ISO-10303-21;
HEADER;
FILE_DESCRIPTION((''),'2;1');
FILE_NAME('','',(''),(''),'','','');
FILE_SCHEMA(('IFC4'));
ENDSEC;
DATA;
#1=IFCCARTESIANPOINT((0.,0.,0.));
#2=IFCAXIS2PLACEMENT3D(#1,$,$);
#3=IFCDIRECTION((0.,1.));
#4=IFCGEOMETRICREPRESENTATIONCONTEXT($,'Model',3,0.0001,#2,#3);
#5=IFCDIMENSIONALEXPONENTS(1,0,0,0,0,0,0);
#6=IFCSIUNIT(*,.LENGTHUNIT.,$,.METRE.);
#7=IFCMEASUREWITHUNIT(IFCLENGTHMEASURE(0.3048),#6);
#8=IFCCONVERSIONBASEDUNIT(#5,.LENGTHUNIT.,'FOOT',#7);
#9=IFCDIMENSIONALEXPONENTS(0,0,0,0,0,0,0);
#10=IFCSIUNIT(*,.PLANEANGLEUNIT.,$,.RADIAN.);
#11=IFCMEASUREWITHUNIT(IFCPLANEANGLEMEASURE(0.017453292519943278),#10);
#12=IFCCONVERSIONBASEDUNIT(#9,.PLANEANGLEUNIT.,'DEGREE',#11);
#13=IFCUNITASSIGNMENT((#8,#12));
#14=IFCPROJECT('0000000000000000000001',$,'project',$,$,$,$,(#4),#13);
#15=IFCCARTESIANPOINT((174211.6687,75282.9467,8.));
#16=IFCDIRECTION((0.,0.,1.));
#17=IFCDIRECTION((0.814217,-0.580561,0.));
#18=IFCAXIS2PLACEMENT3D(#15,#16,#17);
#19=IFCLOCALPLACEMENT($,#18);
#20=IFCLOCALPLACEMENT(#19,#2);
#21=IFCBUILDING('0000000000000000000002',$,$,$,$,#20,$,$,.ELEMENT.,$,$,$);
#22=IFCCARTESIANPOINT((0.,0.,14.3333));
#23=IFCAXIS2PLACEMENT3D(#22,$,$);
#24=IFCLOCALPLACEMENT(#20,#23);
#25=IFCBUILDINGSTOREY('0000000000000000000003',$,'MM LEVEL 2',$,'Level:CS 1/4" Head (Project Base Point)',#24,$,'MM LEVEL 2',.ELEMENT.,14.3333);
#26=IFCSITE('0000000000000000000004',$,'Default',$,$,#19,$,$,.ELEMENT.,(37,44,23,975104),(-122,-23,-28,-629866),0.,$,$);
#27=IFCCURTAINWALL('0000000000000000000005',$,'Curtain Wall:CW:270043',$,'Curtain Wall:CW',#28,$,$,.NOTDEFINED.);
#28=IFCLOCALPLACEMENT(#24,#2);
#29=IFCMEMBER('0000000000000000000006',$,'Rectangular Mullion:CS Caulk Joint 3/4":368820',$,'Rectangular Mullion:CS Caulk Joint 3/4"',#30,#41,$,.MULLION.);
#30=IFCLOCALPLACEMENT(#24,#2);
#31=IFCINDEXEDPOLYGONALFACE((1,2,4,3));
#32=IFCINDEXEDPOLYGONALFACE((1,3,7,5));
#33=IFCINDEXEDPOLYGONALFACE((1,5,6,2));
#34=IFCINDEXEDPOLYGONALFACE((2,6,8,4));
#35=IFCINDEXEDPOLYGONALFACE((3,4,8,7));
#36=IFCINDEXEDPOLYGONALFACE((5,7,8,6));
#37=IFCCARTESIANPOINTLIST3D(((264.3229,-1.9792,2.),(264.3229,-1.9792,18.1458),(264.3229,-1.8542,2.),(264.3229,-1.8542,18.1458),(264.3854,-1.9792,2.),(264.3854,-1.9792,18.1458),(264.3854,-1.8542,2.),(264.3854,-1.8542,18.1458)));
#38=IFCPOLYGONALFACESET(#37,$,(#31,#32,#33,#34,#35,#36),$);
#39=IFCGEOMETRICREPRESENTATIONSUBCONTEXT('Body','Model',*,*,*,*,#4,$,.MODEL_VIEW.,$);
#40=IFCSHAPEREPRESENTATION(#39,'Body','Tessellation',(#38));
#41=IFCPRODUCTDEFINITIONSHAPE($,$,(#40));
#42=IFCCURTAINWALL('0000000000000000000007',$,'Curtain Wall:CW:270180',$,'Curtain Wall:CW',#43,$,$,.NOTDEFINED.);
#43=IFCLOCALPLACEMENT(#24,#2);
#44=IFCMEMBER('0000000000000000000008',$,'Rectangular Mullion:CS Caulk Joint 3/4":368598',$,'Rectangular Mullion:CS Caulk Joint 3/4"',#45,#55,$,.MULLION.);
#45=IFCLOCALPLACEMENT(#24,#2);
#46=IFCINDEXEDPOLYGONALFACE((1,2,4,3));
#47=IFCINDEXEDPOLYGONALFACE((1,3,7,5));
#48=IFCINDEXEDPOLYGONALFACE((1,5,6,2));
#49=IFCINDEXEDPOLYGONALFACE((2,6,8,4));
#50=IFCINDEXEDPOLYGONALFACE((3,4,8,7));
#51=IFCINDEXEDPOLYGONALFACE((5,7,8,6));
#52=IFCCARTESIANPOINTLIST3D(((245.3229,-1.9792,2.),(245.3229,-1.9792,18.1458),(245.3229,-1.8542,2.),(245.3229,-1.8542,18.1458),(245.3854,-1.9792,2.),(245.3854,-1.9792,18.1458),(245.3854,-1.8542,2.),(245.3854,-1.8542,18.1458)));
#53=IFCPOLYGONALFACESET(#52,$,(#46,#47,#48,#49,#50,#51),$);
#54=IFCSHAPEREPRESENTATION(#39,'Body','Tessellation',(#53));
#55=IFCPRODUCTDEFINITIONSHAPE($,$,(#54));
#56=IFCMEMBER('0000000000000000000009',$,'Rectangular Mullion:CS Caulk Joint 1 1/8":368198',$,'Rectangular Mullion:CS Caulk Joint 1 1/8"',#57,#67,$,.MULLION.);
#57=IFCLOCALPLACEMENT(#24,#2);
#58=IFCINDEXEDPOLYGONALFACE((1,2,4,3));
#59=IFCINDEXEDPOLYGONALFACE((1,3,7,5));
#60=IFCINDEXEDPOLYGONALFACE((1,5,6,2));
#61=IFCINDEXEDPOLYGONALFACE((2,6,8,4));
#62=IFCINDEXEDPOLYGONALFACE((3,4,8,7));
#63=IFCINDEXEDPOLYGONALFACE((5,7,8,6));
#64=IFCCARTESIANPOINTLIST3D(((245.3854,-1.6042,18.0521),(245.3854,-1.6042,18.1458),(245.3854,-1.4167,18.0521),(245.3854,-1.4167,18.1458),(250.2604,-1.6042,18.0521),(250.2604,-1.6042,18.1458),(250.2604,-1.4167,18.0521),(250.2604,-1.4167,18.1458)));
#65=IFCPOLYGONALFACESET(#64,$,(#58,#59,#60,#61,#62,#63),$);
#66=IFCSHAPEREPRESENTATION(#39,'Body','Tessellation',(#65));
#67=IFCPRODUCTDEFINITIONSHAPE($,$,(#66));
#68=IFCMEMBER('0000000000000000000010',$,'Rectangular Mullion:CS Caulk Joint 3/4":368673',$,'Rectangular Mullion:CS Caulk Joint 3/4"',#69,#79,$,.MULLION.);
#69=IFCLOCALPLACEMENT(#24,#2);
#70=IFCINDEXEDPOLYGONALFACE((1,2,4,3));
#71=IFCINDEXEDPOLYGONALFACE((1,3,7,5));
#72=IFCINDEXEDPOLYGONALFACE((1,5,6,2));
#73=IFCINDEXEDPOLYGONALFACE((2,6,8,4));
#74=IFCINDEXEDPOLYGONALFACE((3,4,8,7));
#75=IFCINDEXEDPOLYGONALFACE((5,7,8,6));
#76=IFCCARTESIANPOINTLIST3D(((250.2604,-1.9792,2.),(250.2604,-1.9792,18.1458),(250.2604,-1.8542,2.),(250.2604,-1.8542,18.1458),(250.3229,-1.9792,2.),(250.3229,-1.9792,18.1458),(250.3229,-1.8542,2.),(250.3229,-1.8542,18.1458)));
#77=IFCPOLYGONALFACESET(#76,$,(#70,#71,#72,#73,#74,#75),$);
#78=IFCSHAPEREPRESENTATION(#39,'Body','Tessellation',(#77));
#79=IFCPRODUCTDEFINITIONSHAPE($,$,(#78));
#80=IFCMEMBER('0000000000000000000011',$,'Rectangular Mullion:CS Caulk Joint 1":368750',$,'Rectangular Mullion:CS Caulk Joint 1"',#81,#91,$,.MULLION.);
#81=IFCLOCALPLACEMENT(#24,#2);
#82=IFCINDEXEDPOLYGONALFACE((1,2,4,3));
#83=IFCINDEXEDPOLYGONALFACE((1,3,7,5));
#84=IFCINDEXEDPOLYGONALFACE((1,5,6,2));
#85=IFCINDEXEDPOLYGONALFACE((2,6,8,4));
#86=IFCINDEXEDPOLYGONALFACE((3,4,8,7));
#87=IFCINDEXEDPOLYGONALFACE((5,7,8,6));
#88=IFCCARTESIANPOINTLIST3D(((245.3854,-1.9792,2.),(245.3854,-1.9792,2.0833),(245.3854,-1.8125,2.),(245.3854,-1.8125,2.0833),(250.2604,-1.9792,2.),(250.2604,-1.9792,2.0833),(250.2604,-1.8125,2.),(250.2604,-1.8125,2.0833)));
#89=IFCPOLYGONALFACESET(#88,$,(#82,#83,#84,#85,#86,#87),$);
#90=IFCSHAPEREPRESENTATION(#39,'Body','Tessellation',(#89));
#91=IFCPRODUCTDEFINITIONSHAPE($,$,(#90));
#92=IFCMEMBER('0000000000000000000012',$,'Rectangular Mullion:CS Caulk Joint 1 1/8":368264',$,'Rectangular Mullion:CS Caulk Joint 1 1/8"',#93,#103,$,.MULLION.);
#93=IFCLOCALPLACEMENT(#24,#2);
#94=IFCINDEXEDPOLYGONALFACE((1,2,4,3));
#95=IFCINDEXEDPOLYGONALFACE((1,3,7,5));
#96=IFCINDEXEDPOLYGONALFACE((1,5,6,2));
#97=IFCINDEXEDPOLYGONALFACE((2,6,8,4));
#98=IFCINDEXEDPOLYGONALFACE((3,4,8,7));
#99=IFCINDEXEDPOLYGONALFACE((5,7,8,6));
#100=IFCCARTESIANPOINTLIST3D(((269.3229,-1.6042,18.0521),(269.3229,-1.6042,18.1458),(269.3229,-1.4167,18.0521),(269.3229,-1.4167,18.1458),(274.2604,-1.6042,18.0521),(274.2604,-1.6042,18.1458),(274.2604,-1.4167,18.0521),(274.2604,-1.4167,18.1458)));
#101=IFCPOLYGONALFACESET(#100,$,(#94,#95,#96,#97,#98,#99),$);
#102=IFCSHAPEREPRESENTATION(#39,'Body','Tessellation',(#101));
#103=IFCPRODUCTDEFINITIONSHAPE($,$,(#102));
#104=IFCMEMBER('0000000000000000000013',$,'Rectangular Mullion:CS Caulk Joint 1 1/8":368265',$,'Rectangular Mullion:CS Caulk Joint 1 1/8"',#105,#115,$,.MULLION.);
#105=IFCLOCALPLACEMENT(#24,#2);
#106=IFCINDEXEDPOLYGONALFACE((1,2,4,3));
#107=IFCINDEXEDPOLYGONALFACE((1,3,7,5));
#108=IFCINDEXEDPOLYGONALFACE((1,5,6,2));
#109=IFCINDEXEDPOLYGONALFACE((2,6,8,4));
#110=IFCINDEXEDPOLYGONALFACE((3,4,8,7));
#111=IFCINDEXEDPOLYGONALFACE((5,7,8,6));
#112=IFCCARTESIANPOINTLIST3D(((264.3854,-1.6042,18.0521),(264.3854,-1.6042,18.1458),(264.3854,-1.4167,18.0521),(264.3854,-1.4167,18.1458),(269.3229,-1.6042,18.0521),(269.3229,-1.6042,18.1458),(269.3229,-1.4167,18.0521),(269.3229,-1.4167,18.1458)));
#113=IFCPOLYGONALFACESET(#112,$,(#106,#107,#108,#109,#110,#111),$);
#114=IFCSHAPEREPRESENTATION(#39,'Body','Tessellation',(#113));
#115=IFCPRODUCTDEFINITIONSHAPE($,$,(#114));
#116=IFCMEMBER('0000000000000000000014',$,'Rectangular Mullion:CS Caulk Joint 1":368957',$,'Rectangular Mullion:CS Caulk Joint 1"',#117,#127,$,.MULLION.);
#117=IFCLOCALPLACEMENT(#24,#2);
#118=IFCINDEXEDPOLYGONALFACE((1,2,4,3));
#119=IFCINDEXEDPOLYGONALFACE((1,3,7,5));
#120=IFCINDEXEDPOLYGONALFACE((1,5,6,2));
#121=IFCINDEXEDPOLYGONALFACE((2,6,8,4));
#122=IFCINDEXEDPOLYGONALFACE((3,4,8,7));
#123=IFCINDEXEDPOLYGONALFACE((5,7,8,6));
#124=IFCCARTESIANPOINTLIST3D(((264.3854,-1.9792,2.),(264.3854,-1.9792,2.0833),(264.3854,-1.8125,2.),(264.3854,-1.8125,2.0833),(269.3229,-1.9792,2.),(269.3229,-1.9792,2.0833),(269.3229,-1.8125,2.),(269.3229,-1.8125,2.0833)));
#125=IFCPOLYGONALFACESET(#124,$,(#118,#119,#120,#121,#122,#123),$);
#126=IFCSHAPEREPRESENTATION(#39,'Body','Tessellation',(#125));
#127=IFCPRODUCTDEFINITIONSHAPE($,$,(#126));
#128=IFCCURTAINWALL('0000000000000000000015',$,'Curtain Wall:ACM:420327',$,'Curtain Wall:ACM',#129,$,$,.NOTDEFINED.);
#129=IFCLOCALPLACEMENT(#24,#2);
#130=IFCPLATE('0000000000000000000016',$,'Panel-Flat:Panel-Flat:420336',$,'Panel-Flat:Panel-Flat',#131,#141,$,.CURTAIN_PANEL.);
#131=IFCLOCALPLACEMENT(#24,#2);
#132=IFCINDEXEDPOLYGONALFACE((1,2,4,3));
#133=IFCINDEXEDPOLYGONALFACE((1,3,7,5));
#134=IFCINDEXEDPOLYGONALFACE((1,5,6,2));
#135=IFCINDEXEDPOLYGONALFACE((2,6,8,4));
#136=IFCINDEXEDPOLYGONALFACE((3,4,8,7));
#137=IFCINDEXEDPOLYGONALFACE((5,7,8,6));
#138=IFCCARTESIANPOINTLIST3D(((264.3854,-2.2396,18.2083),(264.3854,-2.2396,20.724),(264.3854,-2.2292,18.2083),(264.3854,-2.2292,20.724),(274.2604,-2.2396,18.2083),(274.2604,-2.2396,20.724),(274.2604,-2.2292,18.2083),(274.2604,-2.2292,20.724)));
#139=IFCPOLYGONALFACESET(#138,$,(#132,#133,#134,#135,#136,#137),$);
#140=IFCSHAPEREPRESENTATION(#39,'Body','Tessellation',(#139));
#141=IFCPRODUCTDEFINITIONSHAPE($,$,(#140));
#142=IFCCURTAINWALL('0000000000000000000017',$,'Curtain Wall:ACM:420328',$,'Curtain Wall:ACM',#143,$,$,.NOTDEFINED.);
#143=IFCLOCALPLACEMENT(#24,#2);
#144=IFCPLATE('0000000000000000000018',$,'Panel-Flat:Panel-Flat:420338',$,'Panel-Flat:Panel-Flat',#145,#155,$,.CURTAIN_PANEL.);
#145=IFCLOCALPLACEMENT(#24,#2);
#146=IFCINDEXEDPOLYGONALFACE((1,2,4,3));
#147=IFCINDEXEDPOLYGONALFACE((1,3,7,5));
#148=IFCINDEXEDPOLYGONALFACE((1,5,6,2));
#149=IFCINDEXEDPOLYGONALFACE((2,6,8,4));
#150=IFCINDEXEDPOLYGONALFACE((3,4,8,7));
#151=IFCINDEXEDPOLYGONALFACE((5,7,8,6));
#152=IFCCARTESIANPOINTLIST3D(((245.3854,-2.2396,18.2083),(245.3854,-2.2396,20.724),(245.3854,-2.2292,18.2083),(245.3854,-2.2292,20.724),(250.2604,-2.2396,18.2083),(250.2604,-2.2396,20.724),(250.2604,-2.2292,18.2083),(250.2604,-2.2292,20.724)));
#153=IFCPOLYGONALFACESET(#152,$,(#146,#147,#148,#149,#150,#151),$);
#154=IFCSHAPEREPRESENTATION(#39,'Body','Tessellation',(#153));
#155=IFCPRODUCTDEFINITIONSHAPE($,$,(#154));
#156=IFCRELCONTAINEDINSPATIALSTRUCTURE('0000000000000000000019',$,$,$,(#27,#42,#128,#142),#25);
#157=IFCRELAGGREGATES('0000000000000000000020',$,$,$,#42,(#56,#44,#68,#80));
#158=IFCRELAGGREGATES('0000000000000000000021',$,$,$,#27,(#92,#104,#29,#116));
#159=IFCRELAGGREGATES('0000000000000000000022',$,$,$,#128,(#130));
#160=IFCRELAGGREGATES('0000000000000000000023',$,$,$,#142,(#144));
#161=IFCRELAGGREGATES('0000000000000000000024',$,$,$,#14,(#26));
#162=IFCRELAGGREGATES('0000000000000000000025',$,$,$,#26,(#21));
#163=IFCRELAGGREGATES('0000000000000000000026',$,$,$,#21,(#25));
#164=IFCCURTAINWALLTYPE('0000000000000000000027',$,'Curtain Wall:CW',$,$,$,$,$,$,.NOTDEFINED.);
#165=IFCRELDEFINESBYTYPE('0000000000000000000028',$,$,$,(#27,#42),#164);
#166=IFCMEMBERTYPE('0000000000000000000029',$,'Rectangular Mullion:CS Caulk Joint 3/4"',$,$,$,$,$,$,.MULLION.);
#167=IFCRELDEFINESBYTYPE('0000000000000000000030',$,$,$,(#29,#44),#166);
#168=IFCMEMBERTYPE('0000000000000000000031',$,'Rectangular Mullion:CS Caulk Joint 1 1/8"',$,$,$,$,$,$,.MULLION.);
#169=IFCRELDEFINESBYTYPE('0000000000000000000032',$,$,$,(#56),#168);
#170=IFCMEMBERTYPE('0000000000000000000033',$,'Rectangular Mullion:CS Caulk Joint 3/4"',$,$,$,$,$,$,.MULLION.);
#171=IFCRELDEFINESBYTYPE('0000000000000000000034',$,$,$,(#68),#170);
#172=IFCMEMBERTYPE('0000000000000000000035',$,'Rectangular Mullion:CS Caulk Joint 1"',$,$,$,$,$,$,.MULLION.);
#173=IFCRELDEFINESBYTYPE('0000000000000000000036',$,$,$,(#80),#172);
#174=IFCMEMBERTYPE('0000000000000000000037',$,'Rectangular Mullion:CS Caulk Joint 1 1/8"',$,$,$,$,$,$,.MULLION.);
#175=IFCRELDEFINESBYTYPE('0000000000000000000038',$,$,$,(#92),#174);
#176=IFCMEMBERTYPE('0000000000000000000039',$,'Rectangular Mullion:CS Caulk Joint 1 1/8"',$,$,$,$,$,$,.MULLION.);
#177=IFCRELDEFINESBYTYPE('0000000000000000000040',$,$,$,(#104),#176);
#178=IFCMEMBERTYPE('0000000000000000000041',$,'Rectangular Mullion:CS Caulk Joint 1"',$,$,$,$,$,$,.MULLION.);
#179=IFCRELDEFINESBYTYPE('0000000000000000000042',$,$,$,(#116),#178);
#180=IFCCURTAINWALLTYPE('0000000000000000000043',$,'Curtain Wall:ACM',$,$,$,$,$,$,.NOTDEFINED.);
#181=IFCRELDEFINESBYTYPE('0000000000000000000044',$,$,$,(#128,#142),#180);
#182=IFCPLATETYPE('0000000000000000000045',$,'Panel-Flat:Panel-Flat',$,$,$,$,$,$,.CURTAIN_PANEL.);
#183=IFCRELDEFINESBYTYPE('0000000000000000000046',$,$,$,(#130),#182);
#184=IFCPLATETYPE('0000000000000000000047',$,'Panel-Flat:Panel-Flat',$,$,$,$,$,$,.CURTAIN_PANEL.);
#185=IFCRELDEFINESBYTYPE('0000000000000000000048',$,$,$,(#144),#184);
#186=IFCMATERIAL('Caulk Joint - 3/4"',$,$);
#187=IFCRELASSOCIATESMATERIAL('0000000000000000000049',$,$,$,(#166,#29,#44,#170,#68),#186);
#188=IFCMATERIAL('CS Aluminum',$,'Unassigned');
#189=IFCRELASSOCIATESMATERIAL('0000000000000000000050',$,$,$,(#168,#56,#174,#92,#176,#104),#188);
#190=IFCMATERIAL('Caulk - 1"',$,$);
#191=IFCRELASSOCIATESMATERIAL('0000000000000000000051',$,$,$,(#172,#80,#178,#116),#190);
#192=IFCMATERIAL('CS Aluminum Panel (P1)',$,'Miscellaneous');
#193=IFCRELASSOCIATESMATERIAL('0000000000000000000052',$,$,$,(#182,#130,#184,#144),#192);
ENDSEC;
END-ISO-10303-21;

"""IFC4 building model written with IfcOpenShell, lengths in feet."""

from ifc_helpers import new_model, entity, si_unit, converted_unit, direction, frame, origin, place, context, subcontext, project, spatial, indexed_curve, outline, extrude, source, transform, mapped, material, type_object, type_shapes, element, aggregate, save


model = new_model("IFC4")

# Units and contexts
model_context = context("Model", 3, precision=0.0001, world=origin(), true_north=direction((0.0, 1.0)))
body_context = subcontext(model_context, "Body", "Model", "MODEL_VIEW")
ifc_project = project(units=[converted_unit("LENGTHUNIT", "FOOT", entity("IfcLengthMeasure", 0.3048), si_unit("LENGTHUNIT", "METRE"), dimensions=[1, 0, 0, 0, 0, 0, 0]), converted_unit("PLANEANGLEUNIT", "DEGREE", entity("IfcPlaneAngleMeasure", 0.017453292519943278), si_unit("PLANEANGLEUNIT", "RADIAN"), dimensions=[0, 0, 0, 0, 0, 0, 0])], contexts=[model_context])

# Site, building, storey
site_placement = place(None, frame((174211.6687, 75282.9467, 8.0), z_axis=(0.0, 0.0, 1.0), x_axis=(0.814217, -0.580561, 0.0)))
site = spatial("IfcSite", under=ifc_project, at=site_placement, Name="Default", CompositionType="ELEMENT", RefLatitude=(37, 44, 23, 975104), RefLongitude=(-122, -23, -28, -629866), RefElevation=0.0)
building_placement = place(site_placement, origin())
building = spatial("IfcBuilding", under=site, at=building_placement, CompositionType="ELEMENT")
storey_placement = place(building_placement, frame((0.0, 0.0, 14.3333)))
storey = spatial("IfcBuildingStorey", under=building, at=storey_placement, Name="MM LEVEL 2", ObjectType="Level:CS 1/4\" Head (Project Base Point)", LongName="MM LEVEL 2", CompositionType="ELEMENT", Elevation=14.3333)

# Curtain wall, member
curtain_wall_type_1 = type_object("IfcCurtainWallType", Name="Curtain Wall:CW", PredefinedType="NOTDEFINED")
curtain_wall_1_placement = place(storey_placement, frame((0.0, 0.0, -14.3333)))
curtain_wall_1 = element("IfcCurtainWall", 1, at=curtain_wall_1_placement, inside=storey, type_object=curtain_wall_type_1, Name="Curtain Wall:CW:270043", ObjectType="Curtain Wall:CW", PredefinedType="NOTDEFINED")
ifc_material_1 = material(Name="Caulk Joint - 3/4\"")
member_type_1 = type_object("IfcMemberType", Name="Rectangular Mullion:CS Caulk Joint 3/4\"", PredefinedType="MULLION", material=ifc_material_1)
shared_shape_1 = source(origin(), body_context, "Body", "SweptSolid", [
    extrude(outline(indexed_curve([(-0.0625, -0.0312), (0.0625, -0.0312), (0.0625, 0.0312), (-0.0625, 0.0312), (-0.0625, -0.0312)], self_intersect=False)), frame((-0.0312, 0.0625, -16.1458), z_axis=(0.0, 0.0, 1.0), x_axis=(0.0, -1.0, 0.0)), (0.0, 0.0, 1.0), 16.1458),
])
type_shapes(member_type_1, [shared_shape_1])
member_1_placement = place(curtain_wall_1_placement, frame((264.3229, -1.9792, 16.3333), z_axis=(0.0, 0.0, -1.0), x_axis=(-1.0, 0.0, 0.0)))
member_1 = element("IfcMember", 2, at=member_1_placement, type_object=member_type_1, material=ifc_material_1, Name="Rectangular Mullion:CS Caulk Joint 3/4\":368820", ObjectType="Rectangular Mullion:CS Caulk Joint 3/4\"", PredefinedType="MULLION", context=body_context, shape_type="MappedRepresentation", body=[
    mapped(shared_shape_1, transform((0.0, 0.0, 0.0), scale=1.0)),
])

# Curtain wall, members
curtain_wall_2_placement = place(storey_placement, frame((0.0, 0.0, -14.3333)))
curtain_wall_2 = element("IfcCurtainWall", 3, at=curtain_wall_2_placement, inside=storey, type_object=curtain_wall_type_1, Name="Curtain Wall:CW:270180", ObjectType="Curtain Wall:CW", PredefinedType="NOTDEFINED")
member_2_placement = place(curtain_wall_2_placement, frame((245.3229, -1.9792, 16.3333), z_axis=(0.0, 0.0, -1.0), x_axis=(-1.0, 0.0, 0.0)))
member_2 = element("IfcMember", 4, at=member_2_placement, type_object=member_type_1, material=ifc_material_1, Name="Rectangular Mullion:CS Caulk Joint 3/4\":368598", ObjectType="Rectangular Mullion:CS Caulk Joint 3/4\"", PredefinedType="MULLION", context=body_context, shape_type="MappedRepresentation", body=[
    mapped(shared_shape_1, transform((0.0, 0.0, 0.0), scale=1.0)),
])
ifc_material_2 = material(Name="CS Aluminum", Category="Unassigned")
member_type_2 = type_object("IfcMemberType", Name="Rectangular Mullion:CS Caulk Joint 1 1/8\"", PredefinedType="MULLION", material=ifc_material_2)
shared_shape_2 = source(origin(), body_context, "Body", "SweptSolid", [
    extrude(outline(indexed_curve([(-0.0937, -0.0469), (0.0938, -0.0469), (0.0938, 0.0469), (-0.0937, 0.0469), (-0.0937, -0.0469)], self_intersect=False)), frame((-0.0469, 0.4688, -4.875), z_axis=(0.0, 0.0, 1.0), x_axis=(0.0, -1.0, 0.0)), (0.0, 0.0, 1.0), 4.875),
])
type_shapes(member_type_2, [shared_shape_2])
member_3_placement = place(curtain_wall_2_placement, frame((245.3854, -1.9792, 32.4792), z_axis=(-1.0, 0.0, 0.0), x_axis=(0.0, 0.0, 1.0)))
member_3 = element("IfcMember", 5, at=member_3_placement, type_object=member_type_2, material=ifc_material_2, Name="Rectangular Mullion:CS Caulk Joint 1 1/8\":368198", ObjectType="Rectangular Mullion:CS Caulk Joint 1 1/8\"", PredefinedType="MULLION", context=body_context, shape_type="MappedRepresentation", body=[
    mapped(shared_shape_2, transform((0.0, 0.0, 0.0), scale=1.0)),
])
member_type_3 = type_object("IfcMemberType", Name="Rectangular Mullion:CS Caulk Joint 3/4\"", PredefinedType="MULLION", material=ifc_material_1)
shared_shape_3 = source(origin(), body_context, "Body", "SweptSolid", [
    extrude(outline(indexed_curve([(-0.0312, -0.0625), (0.0312, -0.0625), (0.0312, 0.0625), (-0.0312, 0.0625), (-0.0312, -0.0625)], self_intersect=False)), frame((-0.0312, 0.0625, -16.1458), z_axis=(0.0, 0.0, 1.0), x_axis=(-1.0, 0.0, 0.0)), (0.0, 0.0, 1.0), 16.1458),
])
type_shapes(member_type_3, [shared_shape_3])
member_4_placement = place(curtain_wall_2_placement, frame((250.3229, -1.9792, 32.4792)))
member_4 = element("IfcMember", 6, at=member_4_placement, type_object=member_type_3, material=ifc_material_1, Name="Rectangular Mullion:CS Caulk Joint 3/4\":368673", ObjectType="Rectangular Mullion:CS Caulk Joint 3/4\"", PredefinedType="MULLION", context=body_context, shape_type="MappedRepresentation", body=[
    mapped(shared_shape_3, transform((0.0, 0.0, 0.0), scale=1.0)),
])
ifc_material_3 = material(Name="Caulk - 1\"")
member_type_4 = type_object("IfcMemberType", Name="Rectangular Mullion:CS Caulk Joint 1\"", PredefinedType="MULLION", material=ifc_material_3)
shared_shape_4 = source(origin(), body_context, "Body", "SweptSolid", [
    extrude(outline(indexed_curve([(-0.0417, -0.0833), (0.0417, -0.0833), (0.0417, 0.0833), (-0.0417, 0.0833), (-0.0417, -0.0833)], self_intersect=False)), frame((-0.0417, 0.0833, -4.875), z_axis=(0.0, 0.0, 1.0), x_axis=(-1.0, 0.0, 0.0)), (0.0, 0.0, 1.0), 4.875),
])
type_shapes(member_type_4, [shared_shape_4])
member_5_placement = place(curtain_wall_2_placement, frame((250.2604, -1.9792, 16.3333), z_axis=(1.0, 0.0, 0.0), x_axis=(0.0, 0.0, -1.0)))
member_5 = element("IfcMember", 7, at=member_5_placement, type_object=member_type_4, material=ifc_material_3, Name="Rectangular Mullion:CS Caulk Joint 1\":368750", ObjectType="Rectangular Mullion:CS Caulk Joint 1\"", PredefinedType="MULLION", context=body_context, shape_type="MappedRepresentation", body=[
    mapped(shared_shape_4, transform((0.0, 0.0, 0.0), scale=1.0)),
])
aggregate(curtain_wall_2, [member_3, member_2, member_4, member_5])

# Members
member_type_5 = type_object("IfcMemberType", Name="Rectangular Mullion:CS Caulk Joint 1 1/8\"", PredefinedType="MULLION", material=ifc_material_2)
shared_shape_5 = source(origin(), body_context, "Body", "SweptSolid", [
    extrude(outline(indexed_curve([(-0.0937, -0.0469), (0.0938, -0.0469), (0.0938, 0.0469), (-0.0937, 0.0469), (-0.0937, -0.0469)], self_intersect=False)), frame((-0.0469, 0.4688, -4.9375), z_axis=(0.0, 0.0, 1.0), x_axis=(0.0, -1.0, 0.0)), (0.0, 0.0, 1.0), 4.9375),
])
type_shapes(member_type_5, [shared_shape_5])
member_6_placement = place(curtain_wall_1_placement, frame((269.3229, -1.9792, 32.4792), z_axis=(-1.0, 0.0, 0.0), x_axis=(0.0, 0.0, 1.0)))
member_6 = element("IfcMember", 8, at=member_6_placement, type_object=member_type_5, material=ifc_material_2, Name="Rectangular Mullion:CS Caulk Joint 1 1/8\":368264", ObjectType="Rectangular Mullion:CS Caulk Joint 1 1/8\"", PredefinedType="MULLION", context=body_context, shape_type="MappedRepresentation", body=[
    mapped(shared_shape_5, transform((0.0, 0.0, 0.0), scale=1.0)),
])
member_type_6 = type_object("IfcMemberType", Name="Rectangular Mullion:CS Caulk Joint 1 1/8\"", PredefinedType="MULLION", material=ifc_material_2)
shared_shape_6 = source(origin(), body_context, "Body", "SweptSolid", [
    extrude(outline(indexed_curve([(-0.0937, -0.0469), (0.0938, -0.0469), (0.0938, 0.0469), (-0.0937, 0.0469), (-0.0937, -0.0469)], self_intersect=False)), frame((-0.0469, 0.4688, -4.9375), z_axis=(0.0, 0.0, 1.0), x_axis=(0.0, -1.0, 0.0)), (0.0, 0.0, 1.0), 4.9375),
])
type_shapes(member_type_6, [shared_shape_6])
member_7_placement = place(curtain_wall_1_placement, frame((264.3854, -1.9792, 32.4792), z_axis=(-1.0, 0.0, 0.0), x_axis=(0.0, 0.0, 1.0)))
member_7 = element("IfcMember", 9, at=member_7_placement, type_object=member_type_6, material=ifc_material_2, Name="Rectangular Mullion:CS Caulk Joint 1 1/8\":368265", ObjectType="Rectangular Mullion:CS Caulk Joint 1 1/8\"", PredefinedType="MULLION", context=body_context, shape_type="MappedRepresentation", body=[
    mapped(shared_shape_6, transform((0.0, 0.0, 0.0), scale=1.0)),
])
member_type_7 = type_object("IfcMemberType", Name="Rectangular Mullion:CS Caulk Joint 1\"", PredefinedType="MULLION", material=ifc_material_3)
shared_shape_7 = source(origin(), body_context, "Body", "SweptSolid", [
    extrude(outline(indexed_curve([(-0.0417, -0.0833), (0.0417, -0.0833), (0.0417, 0.0833), (-0.0417, 0.0833), (-0.0417, -0.0833)], self_intersect=False)), frame((-0.0417, 0.0833, -4.9375), z_axis=(0.0, 0.0, 1.0), x_axis=(-1.0, 0.0, 0.0)), (0.0, 0.0, 1.0), 4.9375),
])
type_shapes(member_type_7, [shared_shape_7])
member_8_placement = place(curtain_wall_1_placement, frame((269.3229, -1.9792, 16.3333), z_axis=(1.0, 0.0, 0.0), x_axis=(0.0, 0.0, -1.0)))
member_8 = element("IfcMember", 10, at=member_8_placement, type_object=member_type_7, material=ifc_material_3, Name="Rectangular Mullion:CS Caulk Joint 1\":368957", ObjectType="Rectangular Mullion:CS Caulk Joint 1\"", PredefinedType="MULLION", context=body_context, shape_type="MappedRepresentation", body=[
    mapped(shared_shape_7, transform((0.0, 0.0, 0.0), scale=1.0)),
])
aggregate(curtain_wall_1, [member_6, member_7, member_1, member_8])

# Curtain walls, plates
curtain_wall_type_2 = type_object("IfcCurtainWallType", Name="Curtain Wall:ACM", PredefinedType="NOTDEFINED")
curtain_wall_3_placement = place(storey_placement, frame((0.0, 0.0, -14.3333)))
curtain_wall_3 = element("IfcCurtainWall", 11, at=curtain_wall_3_placement, inside=storey, type_object=curtain_wall_type_2, Name="Curtain Wall:ACM:420327", ObjectType="Curtain Wall:ACM", PredefinedType="NOTDEFINED")
ifc_material_4 = material(Name="CS Aluminum Panel (P1)", Category="Miscellaneous")
plate_type_1 = type_object("IfcPlateType", Name="Panel-Flat:Panel-Flat", PredefinedType="CURTAIN_PANEL", material=ifc_material_4)
shared_shape_8 = source(origin(), body_context, "Body", "SweptSolid", [
    extrude(outline(indexed_curve([(-0.0052, -4.9375), (0.0052, -4.9375), (0.0052, 4.9375), (-0.0052, 4.9375), (-0.0052, -4.9375)], self_intersect=False)), frame((0.0, -0.0052, 0.0), z_axis=(0.0, 0.0, 1.0), x_axis=(0.0, -1.0, 0.0)), (0.0, 0.0, 1.0), 2.5156),
])
type_shapes(plate_type_1, [shared_shape_8])
plate_1_placement = place(curtain_wall_3_placement, frame((269.3229, -2.2396, 32.5417), z_axis=(0.0, 0.0, 1.0), x_axis=(-1.0, 0.0, 0.0)))
plate_1 = element("IfcPlate", 12, at=plate_1_placement, type_object=plate_type_1, material=ifc_material_4, Name="Panel-Flat:Panel-Flat:420336", ObjectType="Panel-Flat:Panel-Flat", PredefinedType="CURTAIN_PANEL", context=body_context, shape_type="MappedRepresentation", body=[
    mapped(shared_shape_8, transform((0.0, 0.0, 0.0), scale=1.0)),
])
aggregate(curtain_wall_3, [plate_1])
curtain_wall_4_placement = place(storey_placement, frame((0.0, 0.0, -14.3333)))
curtain_wall_4 = element("IfcCurtainWall", 13, at=curtain_wall_4_placement, inside=storey, type_object=curtain_wall_type_2, Name="Curtain Wall:ACM:420328", ObjectType="Curtain Wall:ACM", PredefinedType="NOTDEFINED")
plate_type_2 = type_object("IfcPlateType", Name="Panel-Flat:Panel-Flat", PredefinedType="CURTAIN_PANEL", material=ifc_material_4)
shared_shape_9 = source(origin(), body_context, "Body", "SweptSolid", [
    extrude(outline(indexed_curve([(-0.0052, -2.4375), (0.0052, -2.4375), (0.0052, 2.4375), (-0.0052, 2.4375), (-0.0052, -2.4375)], self_intersect=False)), frame((0.0, -0.0052, 0.0), z_axis=(0.0, 0.0, 1.0), x_axis=(0.0, -1.0, 0.0)), (0.0, 0.0, 1.0), 2.5156),
])
type_shapes(plate_type_2, [shared_shape_9])
plate_2_placement = place(curtain_wall_4_placement, frame((247.8229, -2.2396, 32.5417), z_axis=(0.0, 0.0, 1.0), x_axis=(-1.0, 0.0, 0.0)))
plate_2 = element("IfcPlate", 14, at=plate_2_placement, type_object=plate_type_2, material=ifc_material_4, Name="Panel-Flat:Panel-Flat:420338", ObjectType="Panel-Flat:Panel-Flat", PredefinedType="CURTAIN_PANEL", context=body_context, shape_type="MappedRepresentation", body=[
    mapped(shared_shape_9, transform((0.0, 0.0, 0.0), scale=1.0)),
])
aggregate(curtain_wall_4, [plate_2])

save(model, "model.ifc")
